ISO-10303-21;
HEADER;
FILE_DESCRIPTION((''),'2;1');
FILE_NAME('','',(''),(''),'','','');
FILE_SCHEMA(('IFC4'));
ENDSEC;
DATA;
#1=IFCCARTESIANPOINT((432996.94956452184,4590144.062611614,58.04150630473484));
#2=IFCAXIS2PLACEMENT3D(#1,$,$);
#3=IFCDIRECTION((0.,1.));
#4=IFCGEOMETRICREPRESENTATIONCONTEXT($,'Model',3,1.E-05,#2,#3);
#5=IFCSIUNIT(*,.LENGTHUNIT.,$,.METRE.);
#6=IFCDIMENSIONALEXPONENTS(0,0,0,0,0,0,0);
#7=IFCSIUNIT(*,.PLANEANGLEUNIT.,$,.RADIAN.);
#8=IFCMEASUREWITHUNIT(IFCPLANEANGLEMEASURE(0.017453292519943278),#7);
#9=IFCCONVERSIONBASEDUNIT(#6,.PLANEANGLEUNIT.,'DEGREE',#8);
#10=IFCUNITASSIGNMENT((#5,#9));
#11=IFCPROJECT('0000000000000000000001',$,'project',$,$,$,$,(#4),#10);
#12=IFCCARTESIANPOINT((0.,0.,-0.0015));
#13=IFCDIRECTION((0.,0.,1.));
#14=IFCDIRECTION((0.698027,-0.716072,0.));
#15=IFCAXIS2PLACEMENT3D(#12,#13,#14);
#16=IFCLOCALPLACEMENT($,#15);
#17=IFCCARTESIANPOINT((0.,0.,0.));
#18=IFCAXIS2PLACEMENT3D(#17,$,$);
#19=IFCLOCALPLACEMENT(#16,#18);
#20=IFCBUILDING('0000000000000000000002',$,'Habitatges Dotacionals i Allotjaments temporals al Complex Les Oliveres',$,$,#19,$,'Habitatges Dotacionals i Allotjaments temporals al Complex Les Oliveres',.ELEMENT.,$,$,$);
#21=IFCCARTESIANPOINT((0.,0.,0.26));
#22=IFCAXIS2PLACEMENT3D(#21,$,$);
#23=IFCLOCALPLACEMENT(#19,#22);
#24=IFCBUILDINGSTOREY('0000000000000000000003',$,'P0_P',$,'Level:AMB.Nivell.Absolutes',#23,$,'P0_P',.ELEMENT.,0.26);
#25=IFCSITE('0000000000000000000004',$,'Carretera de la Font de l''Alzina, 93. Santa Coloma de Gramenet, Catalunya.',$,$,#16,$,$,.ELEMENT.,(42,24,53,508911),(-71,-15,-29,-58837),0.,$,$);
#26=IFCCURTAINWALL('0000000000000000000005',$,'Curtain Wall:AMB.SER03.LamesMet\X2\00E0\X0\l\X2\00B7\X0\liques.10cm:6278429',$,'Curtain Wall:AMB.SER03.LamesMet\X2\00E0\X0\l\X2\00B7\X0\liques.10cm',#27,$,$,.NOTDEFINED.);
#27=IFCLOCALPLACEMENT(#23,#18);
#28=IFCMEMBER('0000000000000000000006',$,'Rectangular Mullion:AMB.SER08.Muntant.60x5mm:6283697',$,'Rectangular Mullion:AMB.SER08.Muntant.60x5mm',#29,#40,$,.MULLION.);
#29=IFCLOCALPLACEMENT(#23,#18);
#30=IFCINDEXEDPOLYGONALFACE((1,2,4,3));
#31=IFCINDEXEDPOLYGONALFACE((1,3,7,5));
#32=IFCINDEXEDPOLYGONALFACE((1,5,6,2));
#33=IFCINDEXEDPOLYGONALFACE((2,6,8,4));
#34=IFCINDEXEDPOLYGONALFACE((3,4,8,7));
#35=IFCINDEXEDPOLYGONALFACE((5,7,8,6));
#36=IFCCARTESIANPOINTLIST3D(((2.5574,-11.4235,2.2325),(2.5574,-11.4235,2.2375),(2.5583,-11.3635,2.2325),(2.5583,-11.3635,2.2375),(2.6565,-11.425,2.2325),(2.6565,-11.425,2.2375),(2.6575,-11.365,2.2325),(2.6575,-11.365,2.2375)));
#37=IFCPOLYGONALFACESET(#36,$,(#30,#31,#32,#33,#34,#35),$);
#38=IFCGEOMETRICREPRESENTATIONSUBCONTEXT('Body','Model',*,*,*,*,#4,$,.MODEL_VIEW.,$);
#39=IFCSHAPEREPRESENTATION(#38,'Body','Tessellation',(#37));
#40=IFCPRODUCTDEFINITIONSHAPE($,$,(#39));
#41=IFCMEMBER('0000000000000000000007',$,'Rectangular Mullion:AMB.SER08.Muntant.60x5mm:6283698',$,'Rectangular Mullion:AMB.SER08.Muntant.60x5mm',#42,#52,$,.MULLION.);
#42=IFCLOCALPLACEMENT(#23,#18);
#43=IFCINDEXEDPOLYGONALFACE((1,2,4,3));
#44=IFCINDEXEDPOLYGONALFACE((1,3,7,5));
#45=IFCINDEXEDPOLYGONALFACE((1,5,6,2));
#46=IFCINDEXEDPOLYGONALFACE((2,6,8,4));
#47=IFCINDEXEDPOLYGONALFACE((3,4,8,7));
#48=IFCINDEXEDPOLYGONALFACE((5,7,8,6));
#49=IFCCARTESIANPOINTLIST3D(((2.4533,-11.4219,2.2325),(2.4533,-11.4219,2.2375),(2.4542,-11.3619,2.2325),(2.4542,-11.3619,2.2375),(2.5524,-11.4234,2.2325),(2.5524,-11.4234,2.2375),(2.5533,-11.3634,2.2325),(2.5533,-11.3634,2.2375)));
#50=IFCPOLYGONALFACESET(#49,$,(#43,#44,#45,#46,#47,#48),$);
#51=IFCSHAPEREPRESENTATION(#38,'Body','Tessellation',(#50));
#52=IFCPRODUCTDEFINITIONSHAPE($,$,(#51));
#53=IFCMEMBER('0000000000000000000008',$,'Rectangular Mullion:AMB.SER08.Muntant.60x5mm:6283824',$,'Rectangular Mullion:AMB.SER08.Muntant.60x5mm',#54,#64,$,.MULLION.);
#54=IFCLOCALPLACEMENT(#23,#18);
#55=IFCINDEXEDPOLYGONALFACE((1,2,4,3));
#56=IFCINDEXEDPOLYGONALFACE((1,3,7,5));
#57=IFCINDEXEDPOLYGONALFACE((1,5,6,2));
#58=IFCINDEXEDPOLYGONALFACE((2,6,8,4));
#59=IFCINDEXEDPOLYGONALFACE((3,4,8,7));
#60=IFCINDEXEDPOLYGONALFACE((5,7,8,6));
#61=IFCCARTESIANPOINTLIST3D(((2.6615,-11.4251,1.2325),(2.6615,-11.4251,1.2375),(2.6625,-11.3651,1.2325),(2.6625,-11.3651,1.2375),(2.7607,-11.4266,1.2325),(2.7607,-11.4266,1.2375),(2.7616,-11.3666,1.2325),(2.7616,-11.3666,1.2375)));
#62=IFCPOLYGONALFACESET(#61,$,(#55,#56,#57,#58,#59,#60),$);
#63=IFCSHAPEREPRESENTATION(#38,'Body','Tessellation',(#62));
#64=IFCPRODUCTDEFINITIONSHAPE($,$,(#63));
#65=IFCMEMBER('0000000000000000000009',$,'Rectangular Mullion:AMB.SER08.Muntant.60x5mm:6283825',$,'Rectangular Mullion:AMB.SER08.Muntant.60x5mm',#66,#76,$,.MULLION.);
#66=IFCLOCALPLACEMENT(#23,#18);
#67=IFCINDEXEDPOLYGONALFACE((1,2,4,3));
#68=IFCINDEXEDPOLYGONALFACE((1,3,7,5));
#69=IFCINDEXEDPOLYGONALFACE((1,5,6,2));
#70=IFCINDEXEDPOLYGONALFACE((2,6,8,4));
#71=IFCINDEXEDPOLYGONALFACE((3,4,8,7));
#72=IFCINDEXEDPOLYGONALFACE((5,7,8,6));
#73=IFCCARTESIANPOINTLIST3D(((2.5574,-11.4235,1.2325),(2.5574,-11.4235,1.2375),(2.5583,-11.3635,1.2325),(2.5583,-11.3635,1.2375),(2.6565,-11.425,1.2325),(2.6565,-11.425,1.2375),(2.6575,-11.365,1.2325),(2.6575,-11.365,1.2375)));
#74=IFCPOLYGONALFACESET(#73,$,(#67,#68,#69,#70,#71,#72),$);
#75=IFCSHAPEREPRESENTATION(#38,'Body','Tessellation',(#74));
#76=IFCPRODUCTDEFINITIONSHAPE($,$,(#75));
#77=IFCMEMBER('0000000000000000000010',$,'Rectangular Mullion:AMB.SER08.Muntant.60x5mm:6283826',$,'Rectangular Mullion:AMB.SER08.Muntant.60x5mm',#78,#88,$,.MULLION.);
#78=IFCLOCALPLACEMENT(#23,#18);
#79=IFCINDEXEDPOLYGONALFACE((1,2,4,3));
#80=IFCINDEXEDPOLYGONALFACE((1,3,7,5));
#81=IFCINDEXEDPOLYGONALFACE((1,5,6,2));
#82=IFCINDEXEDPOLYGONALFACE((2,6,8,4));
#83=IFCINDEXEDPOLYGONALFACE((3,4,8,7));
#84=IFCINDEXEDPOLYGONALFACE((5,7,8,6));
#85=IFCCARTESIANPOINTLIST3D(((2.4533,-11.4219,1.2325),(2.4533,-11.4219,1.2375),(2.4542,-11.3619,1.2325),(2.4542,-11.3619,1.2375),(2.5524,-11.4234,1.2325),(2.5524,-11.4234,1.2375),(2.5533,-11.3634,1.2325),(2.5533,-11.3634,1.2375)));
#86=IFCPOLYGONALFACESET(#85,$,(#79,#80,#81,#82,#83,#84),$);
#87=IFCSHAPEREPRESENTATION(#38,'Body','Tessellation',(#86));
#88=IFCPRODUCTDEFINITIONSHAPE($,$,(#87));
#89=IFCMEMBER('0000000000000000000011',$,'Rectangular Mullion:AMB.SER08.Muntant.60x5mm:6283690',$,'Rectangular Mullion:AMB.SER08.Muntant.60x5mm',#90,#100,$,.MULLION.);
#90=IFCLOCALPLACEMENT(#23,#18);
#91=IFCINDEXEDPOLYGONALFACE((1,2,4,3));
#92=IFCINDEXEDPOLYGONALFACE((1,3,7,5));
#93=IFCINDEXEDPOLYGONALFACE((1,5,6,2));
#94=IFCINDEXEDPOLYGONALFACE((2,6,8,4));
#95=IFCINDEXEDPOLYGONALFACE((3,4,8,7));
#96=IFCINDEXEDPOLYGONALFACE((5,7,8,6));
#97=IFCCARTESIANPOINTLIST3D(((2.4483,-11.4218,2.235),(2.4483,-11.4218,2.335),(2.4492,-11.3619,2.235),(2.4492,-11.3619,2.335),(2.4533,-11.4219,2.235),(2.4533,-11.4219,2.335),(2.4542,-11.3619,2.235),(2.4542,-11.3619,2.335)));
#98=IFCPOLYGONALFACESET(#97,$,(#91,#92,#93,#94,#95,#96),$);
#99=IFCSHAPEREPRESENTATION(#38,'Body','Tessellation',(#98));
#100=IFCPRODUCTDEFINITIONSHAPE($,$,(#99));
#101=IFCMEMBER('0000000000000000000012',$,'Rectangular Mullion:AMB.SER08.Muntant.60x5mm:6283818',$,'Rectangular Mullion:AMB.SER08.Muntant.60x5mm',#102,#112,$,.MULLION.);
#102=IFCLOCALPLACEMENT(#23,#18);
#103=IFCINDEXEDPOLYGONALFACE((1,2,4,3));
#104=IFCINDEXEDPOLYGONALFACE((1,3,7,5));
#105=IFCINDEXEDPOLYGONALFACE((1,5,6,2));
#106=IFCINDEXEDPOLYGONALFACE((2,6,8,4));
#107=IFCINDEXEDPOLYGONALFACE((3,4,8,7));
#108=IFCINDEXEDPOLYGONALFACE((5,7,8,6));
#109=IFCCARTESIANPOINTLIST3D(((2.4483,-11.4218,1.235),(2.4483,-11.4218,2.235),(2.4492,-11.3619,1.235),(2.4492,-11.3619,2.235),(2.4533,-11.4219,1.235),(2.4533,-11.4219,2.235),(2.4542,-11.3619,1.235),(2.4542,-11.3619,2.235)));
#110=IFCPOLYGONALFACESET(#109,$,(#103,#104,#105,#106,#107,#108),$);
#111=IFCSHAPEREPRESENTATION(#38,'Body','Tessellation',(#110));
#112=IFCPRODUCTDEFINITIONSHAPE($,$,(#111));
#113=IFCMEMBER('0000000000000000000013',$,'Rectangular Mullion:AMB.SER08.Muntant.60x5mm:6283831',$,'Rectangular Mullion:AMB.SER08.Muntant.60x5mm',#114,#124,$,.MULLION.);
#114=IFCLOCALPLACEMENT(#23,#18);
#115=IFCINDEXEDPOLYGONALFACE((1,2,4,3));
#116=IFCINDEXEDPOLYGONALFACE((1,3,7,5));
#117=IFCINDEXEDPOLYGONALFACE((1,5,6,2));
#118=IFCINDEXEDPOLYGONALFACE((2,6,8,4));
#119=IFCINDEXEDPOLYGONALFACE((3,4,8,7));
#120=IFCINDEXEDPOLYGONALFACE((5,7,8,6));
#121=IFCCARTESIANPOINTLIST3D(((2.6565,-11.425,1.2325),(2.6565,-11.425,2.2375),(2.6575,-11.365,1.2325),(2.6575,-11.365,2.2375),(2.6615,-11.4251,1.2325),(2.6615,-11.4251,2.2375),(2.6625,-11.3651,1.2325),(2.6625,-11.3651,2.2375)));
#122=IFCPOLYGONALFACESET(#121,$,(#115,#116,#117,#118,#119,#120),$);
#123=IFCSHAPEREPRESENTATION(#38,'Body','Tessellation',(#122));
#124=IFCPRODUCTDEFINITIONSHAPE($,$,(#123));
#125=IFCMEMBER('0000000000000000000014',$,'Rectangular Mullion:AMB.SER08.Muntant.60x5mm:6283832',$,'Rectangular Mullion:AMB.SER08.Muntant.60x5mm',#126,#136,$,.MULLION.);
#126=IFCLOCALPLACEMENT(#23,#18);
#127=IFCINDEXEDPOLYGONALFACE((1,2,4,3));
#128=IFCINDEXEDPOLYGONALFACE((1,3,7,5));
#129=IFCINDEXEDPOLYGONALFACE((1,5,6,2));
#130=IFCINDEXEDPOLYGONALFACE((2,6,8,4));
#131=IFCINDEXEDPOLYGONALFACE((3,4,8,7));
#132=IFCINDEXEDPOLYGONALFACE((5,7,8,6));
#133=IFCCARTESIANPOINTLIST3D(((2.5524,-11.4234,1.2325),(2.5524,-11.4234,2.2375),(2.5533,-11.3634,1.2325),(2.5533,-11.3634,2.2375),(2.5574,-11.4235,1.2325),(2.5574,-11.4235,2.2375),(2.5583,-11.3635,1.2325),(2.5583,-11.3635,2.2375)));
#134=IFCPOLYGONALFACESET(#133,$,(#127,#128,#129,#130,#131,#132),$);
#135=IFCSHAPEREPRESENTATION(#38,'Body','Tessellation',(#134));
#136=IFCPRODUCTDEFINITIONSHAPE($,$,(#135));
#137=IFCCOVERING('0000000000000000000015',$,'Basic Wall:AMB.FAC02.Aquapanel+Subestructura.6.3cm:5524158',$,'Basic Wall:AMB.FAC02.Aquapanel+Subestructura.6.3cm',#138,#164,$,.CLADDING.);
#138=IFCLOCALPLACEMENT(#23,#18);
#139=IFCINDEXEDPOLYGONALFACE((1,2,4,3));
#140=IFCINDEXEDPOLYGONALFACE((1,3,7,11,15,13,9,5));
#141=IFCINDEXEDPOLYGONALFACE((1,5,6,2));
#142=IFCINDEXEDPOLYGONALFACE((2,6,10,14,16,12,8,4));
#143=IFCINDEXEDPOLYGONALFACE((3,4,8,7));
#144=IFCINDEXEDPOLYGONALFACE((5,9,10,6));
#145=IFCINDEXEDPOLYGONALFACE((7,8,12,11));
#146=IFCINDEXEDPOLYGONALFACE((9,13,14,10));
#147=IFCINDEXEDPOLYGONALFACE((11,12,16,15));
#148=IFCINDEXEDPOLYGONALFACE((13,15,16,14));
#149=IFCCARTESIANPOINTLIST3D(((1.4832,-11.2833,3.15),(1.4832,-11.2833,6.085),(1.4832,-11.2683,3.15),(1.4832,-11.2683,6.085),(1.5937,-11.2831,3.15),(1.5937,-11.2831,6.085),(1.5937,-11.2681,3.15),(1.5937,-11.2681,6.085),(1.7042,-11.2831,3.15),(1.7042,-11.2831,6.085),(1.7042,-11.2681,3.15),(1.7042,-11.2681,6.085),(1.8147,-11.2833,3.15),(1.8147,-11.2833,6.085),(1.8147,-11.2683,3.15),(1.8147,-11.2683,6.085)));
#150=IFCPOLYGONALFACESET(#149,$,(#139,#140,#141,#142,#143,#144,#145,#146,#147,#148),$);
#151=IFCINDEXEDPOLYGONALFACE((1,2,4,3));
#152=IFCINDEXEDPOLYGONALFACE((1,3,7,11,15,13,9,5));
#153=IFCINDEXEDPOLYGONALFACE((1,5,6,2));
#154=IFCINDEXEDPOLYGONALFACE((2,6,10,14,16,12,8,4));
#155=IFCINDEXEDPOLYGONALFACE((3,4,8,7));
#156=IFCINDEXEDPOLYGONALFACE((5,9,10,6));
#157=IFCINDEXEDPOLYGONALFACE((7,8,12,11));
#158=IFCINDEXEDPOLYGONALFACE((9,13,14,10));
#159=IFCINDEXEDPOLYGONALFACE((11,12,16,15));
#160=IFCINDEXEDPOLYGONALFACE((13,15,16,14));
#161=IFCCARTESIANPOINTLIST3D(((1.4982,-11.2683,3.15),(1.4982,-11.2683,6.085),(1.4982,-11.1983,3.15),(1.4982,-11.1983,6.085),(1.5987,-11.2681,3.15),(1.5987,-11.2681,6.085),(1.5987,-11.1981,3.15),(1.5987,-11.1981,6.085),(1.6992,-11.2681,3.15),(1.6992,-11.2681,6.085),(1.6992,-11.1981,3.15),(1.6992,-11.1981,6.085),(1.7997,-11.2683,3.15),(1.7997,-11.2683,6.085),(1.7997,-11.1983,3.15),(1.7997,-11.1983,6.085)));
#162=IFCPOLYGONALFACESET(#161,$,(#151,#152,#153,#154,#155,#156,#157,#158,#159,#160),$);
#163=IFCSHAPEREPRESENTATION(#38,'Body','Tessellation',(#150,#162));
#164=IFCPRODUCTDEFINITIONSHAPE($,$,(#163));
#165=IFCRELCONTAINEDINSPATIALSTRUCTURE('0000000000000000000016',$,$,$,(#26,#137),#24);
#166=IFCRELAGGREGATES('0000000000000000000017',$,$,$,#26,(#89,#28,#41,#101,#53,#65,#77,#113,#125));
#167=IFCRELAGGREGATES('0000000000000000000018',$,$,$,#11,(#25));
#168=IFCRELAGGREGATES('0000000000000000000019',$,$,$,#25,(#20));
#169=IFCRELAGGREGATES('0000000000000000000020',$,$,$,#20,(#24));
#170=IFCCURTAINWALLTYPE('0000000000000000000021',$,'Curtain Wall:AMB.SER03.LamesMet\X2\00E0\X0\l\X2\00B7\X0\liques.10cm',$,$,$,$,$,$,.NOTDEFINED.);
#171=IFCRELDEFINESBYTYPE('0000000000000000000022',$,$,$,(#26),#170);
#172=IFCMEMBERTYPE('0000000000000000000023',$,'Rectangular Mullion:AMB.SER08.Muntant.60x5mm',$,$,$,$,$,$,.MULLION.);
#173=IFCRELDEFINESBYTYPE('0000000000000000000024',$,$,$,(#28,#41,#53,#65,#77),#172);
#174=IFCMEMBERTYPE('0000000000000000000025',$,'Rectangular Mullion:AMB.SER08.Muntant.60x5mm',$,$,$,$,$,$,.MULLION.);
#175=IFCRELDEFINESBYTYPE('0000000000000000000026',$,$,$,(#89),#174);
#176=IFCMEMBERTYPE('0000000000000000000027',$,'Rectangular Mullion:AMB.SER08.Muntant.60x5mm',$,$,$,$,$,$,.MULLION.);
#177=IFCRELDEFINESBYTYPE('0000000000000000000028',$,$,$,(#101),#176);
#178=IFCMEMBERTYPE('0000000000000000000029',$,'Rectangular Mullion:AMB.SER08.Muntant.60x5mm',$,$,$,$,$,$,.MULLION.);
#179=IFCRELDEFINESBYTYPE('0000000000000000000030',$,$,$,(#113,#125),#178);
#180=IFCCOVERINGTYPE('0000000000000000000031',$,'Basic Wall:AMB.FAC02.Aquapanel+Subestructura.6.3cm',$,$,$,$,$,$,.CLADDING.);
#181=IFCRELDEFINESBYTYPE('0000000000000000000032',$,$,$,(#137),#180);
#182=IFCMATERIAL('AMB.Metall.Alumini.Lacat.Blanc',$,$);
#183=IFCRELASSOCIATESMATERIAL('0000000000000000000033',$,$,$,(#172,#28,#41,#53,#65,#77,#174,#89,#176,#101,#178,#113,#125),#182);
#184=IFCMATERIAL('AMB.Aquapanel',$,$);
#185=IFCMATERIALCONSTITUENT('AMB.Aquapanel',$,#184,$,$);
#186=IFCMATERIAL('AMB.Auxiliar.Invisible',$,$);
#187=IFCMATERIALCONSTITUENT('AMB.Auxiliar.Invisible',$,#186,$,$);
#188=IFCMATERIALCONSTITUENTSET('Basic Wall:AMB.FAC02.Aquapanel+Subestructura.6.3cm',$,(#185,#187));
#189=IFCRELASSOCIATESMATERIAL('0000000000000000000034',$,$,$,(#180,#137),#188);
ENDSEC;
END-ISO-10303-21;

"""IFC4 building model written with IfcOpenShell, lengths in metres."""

from ifc_helpers import new_model, entity, si_unit, converted_unit, direction, frame, origin, place, context, subcontext, project, spatial, line, arc, indexed_curve, outline, extrude, source, transform, mapped, material, constituent, constituent_set, type_object, type_shapes, element, aggregate, save


model = new_model("IFC4")

# Units and contexts
model_context = context("Model", 3, precision=1e-05, world=frame((432996.94956452184, 4590144.062611614, 58.04150630473484)), true_north=direction((0.0, 1.0)))
body_context = subcontext(model_context, "Body", "Model", "MODEL_VIEW")
ifc_project = project(units=[si_unit("LENGTHUNIT", "METRE"), converted_unit("PLANEANGLEUNIT", "DEGREE", entity("IfcPlaneAngleMeasure", 0.017453292519943278), si_unit("PLANEANGLEUNIT", "RADIAN"), dimensions=[0, 0, 0, 0, 0, 0, 0])], contexts=[model_context])

# Site, building, storey
site_placement = place(None, frame((0.0, 0.0, -0.0015), z_axis=(0.0, 0.0, 1.0), x_axis=(0.698027, -0.716072, 0.0)))
site = spatial("IfcSite", under=ifc_project, at=site_placement, Name="Carretera de la Font de l'Alzina, 93. Santa Coloma de Gramenet, Catalunya.", CompositionType="ELEMENT", RefLatitude=(42, 24, 53, 508911), RefLongitude=(-71, -15, -29, -58837), RefElevation=0.0)
building_placement = place(site_placement, origin())
building = spatial("IfcBuilding", under=site, at=building_placement, Name="Habitatges Dotacionals i Allotjaments temporals al Complex Les Oliveres", LongName="Habitatges Dotacionals i Allotjaments temporals al Complex Les Oliveres", CompositionType="ELEMENT")
storey_placement = place(building_placement, frame((0.0, 0.0, 0.26)))
storey = spatial("IfcBuildingStorey", under=building, at=storey_placement, Name="P0_P", ObjectType="Level:AMB.Nivell.Absolutes", LongName="P0_P", CompositionType="ELEMENT", Elevation=0.26)

# Shared definitions
ifc_material_1 = material(Name="AMB.Metall.Alumini.Lacat.Blanc")

# Curtain wall, members
curtain_wall_type_1 = type_object("IfcCurtainWallType", Name="Curtain Wall:AMB.SER03.LamesMetàl·liques.10cm", PredefinedType="NOTDEFINED")
curtain_wall_1_placement = place(storey_placement, frame((0.0, 0.0, -0.26)))
curtain_wall_1 = element("IfcCurtainWall", 1, at=curtain_wall_1_placement, inside=storey, type_object=curtain_wall_type_1, Name="Curtain Wall:AMB.SER03.LamesMetàl·liques.10cm:6278429", ObjectType="Curtain Wall:AMB.SER03.LamesMetàl·liques.10cm", PredefinedType="NOTDEFINED")
member_type_1 = type_object("IfcMemberType", Name="Rectangular Mullion:AMB.SER08.Muntant.60x5mm", PredefinedType="MULLION", material=ifc_material_1)
shared_shape_1 = source(origin(), body_context, "Body", "SweptSolid", [
    extrude(outline(indexed_curve([(-0.0025, -0.03), (0.0025, -0.03), (0.0025, 0.03), (-0.0025, 0.03), (-0.0025, -0.03)], self_intersect=False)), frame((0.0, 0.03, -0.0991), z_axis=(0.0, 0.0, 1.0), x_axis=(-1.0, 0.0, 0.0)), (0.0, 0.0, 1.0), 0.0991),
])
type_shapes(member_type_1, [shared_shape_1])
member_1_placement = place(curtain_wall_1_placement, frame((2.5574, -11.4235, 2.495), z_axis=(-0.999883, 0.015319, 0.0), x_axis=(0.0, 0.0, 1.0)))
member_1 = element("IfcMember", 2, at=member_1_placement, type_object=member_type_1, material=ifc_material_1, Name="Rectangular Mullion:AMB.SER08.Muntant.60x5mm:6283697", ObjectType="Rectangular Mullion:AMB.SER08.Muntant.60x5mm", PredefinedType="MULLION", context=body_context, shape_type="MappedRepresentation", body=[
    mapped(shared_shape_1, transform((0.0, 0.0, 0.0), scale=1.0)),
])
member_2_placement = place(curtain_wall_1_placement, frame((2.4533, -11.4219, 2.495), z_axis=(-0.999883, 0.015319, 0.0), x_axis=(0.0, 0.0, 1.0)))
member_2 = element("IfcMember", 3, at=member_2_placement, type_object=member_type_1, material=ifc_material_1, Name="Rectangular Mullion:AMB.SER08.Muntant.60x5mm:6283698", ObjectType="Rectangular Mullion:AMB.SER08.Muntant.60x5mm", PredefinedType="MULLION", context=body_context, shape_type="MappedRepresentation", body=[
    mapped(shared_shape_1, transform((0.0, 0.0, 0.0), scale=1.0)),
])
member_3_placement = place(curtain_wall_1_placement, frame((2.6615, -11.4251, 1.495), z_axis=(-0.999883, 0.015319, 0.0), x_axis=(0.0, 0.0, 1.0)))
member_3 = element("IfcMember", 4, at=member_3_placement, type_object=member_type_1, material=ifc_material_1, Name="Rectangular Mullion:AMB.SER08.Muntant.60x5mm:6283824", ObjectType="Rectangular Mullion:AMB.SER08.Muntant.60x5mm", PredefinedType="MULLION", context=body_context, shape_type="MappedRepresentation", body=[
    mapped(shared_shape_1, transform((0.0, 0.0, 0.0), scale=1.0)),
])
member_4_placement = place(curtain_wall_1_placement, frame((2.5574, -11.4235, 1.495), z_axis=(-0.999883, 0.015319, 0.0), x_axis=(0.0, 0.0, 1.0)))
member_4 = element("IfcMember", 5, at=member_4_placement, type_object=member_type_1, material=ifc_material_1, Name="Rectangular Mullion:AMB.SER08.Muntant.60x5mm:6283825", ObjectType="Rectangular Mullion:AMB.SER08.Muntant.60x5mm", PredefinedType="MULLION", context=body_context, shape_type="MappedRepresentation", body=[
    mapped(shared_shape_1, transform((0.0, 0.0, 0.0), scale=1.0)),
])
member_5_placement = place(curtain_wall_1_placement, frame((2.4533, -11.4219, 1.495), z_axis=(-0.999883, 0.015319, 0.0), x_axis=(0.0, 0.0, 1.0)))
member_5 = element("IfcMember", 6, at=member_5_placement, type_object=member_type_1, material=ifc_material_1, Name="Rectangular Mullion:AMB.SER08.Muntant.60x5mm:6283826", ObjectType="Rectangular Mullion:AMB.SER08.Muntant.60x5mm", PredefinedType="MULLION", context=body_context, shape_type="MappedRepresentation", body=[
    mapped(shared_shape_1, transform((0.0, 0.0, 0.0), scale=1.0)),
])
member_type_2 = type_object("IfcMemberType", Name="Rectangular Mullion:AMB.SER08.Muntant.60x5mm", PredefinedType="MULLION", material=ifc_material_1)
shared_shape_2 = source(origin(), body_context, "Body", "SweptSolid", [
    extrude(outline(indexed_curve([(-0.0025, -0.03), (0.0025, -0.03), (0.0025, 0.03), (-0.0025, 0.03), (-0.0025, -0.03)], self_intersect=False)), frame((-0.0025, 0.03, -0.1), z_axis=(0.0, 0.0, 1.0), x_axis=(-1.0, 0.0, 0.0)), (0.0, 0.0, 1.0), 0.1),
])
type_shapes(member_type_2, [shared_shape_2])
member_6_placement = place(curtain_wall_1_placement, frame((2.4483, -11.4218, 2.495), z_axis=(0.0, 0.0, -1.0), x_axis=(-0.999883, 0.015319, 0.0)))
member_6 = element("IfcMember", 7, at=member_6_placement, type_object=member_type_2, material=ifc_material_1, Name="Rectangular Mullion:AMB.SER08.Muntant.60x5mm:6283690", ObjectType="Rectangular Mullion:AMB.SER08.Muntant.60x5mm", PredefinedType="MULLION", context=body_context, shape_type="MappedRepresentation", body=[
    mapped(shared_shape_2, transform((0.0, 0.0, 0.0), scale=1.0)),
])
member_type_3 = type_object("IfcMemberType", Name="Rectangular Mullion:AMB.SER08.Muntant.60x5mm", PredefinedType="MULLION", material=ifc_material_1)
shared_shape_3 = source(origin(), body_context, "Body", "SweptSolid", [
    extrude(outline(indexed_curve([(-0.0025, -0.03), (0.0025, -0.03), (0.0025, 0.03), (-0.0025, 0.03), (-0.0025, -0.03)], self_intersect=False)), frame((-0.0025, 0.03, -1.0), z_axis=(0.0, 0.0, 1.0), x_axis=(-1.0, 0.0, 0.0)), (0.0, 0.0, 1.0), 1.0),
])
type_shapes(member_type_3, [shared_shape_3])
member_7_placement = place(curtain_wall_1_placement, frame((2.4483, -11.4218, 1.495), z_axis=(0.0, 0.0, -1.0), x_axis=(-0.999883, 0.015319, 0.0)))
member_7 = element("IfcMember", 8, at=member_7_placement, type_object=member_type_3, material=ifc_material_1, Name="Rectangular Mullion:AMB.SER08.Muntant.60x5mm:6283818", ObjectType="Rectangular Mullion:AMB.SER08.Muntant.60x5mm", PredefinedType="MULLION", context=body_context, shape_type="MappedRepresentation", body=[
    mapped(shared_shape_3, transform((0.0, 0.0, 0.0), scale=1.0)),
])
member_type_4 = type_object("IfcMemberType", Name="Rectangular Mullion:AMB.SER08.Muntant.60x5mm", PredefinedType="MULLION", material=ifc_material_1)
shared_shape_4 = source(origin(), body_context, "Body", "SweptSolid", [
    extrude(outline(indexed_curve([(-0.0025, -0.03), (0.0025, -0.03), (0.0025, 0.03), (-0.0025, 0.03), (-0.0025, -0.03)], self_intersect=False)), frame((0.0, 0.03, -1.005), z_axis=(0.0, 0.0, 1.0), x_axis=(-1.0, 0.0, 0.0)), (0.0, 0.0, 1.0), 1.005),
])
type_shapes(member_type_4, [shared_shape_4])
member_8_placement = place(curtain_wall_1_placement, frame((2.659, -11.4251, 1.4925), z_axis=(0.0, 0.0, -1.0), x_axis=(-0.999883, 0.015319, 0.0)))
member_8 = element("IfcMember", 9, at=member_8_placement, type_object=member_type_4, material=ifc_material_1, Name="Rectangular Mullion:AMB.SER08.Muntant.60x5mm:6283831", ObjectType="Rectangular Mullion:AMB.SER08.Muntant.60x5mm", PredefinedType="MULLION", context=body_context, shape_type="MappedRepresentation", body=[
    mapped(shared_shape_4, transform((0.0, 0.0, 0.0), scale=1.0)),
])
member_9_placement = place(curtain_wall_1_placement, frame((2.5549, -11.4235, 1.4925), z_axis=(0.0, 0.0, -1.0), x_axis=(-0.999883, 0.015319, 0.0)))
member_9 = element("IfcMember", 10, at=member_9_placement, type_object=member_type_4, material=ifc_material_1, Name="Rectangular Mullion:AMB.SER08.Muntant.60x5mm:6283832", ObjectType="Rectangular Mullion:AMB.SER08.Muntant.60x5mm", PredefinedType="MULLION", context=body_context, shape_type="MappedRepresentation", body=[
    mapped(shared_shape_4, transform((0.0, 0.0, 0.0), scale=1.0)),
])
aggregate(curtain_wall_1, [member_6, member_1, member_2, member_7, member_3, member_4, member_5, member_8, member_9])

# Covering
ifc_material_2 = material(Name="AMB.Aquapanel")
ifc_constituent_1 = constituent(ifc_material_2, Name="AMB.Aquapanel")
ifc_material_3 = material(Name="AMB.Auxiliar.Invisible")
ifc_constituent_2 = constituent(ifc_material_3, Name="AMB.Auxiliar.Invisible")
ifc_constituent_set = constituent_set(constituents=[ifc_constituent_1, ifc_constituent_2], Name="Basic Wall:AMB.FAC02.Aquapanel+Subestructura.6.3cm")
covering_type_1 = type_object("IfcCoveringType", Name="Basic Wall:AMB.FAC02.Aquapanel+Subestructura.6.3cm", PredefinedType="CLADDING", material=ifc_constituent_set)
covering_1_placement = place(storey_placement, frame((1.8149, -11.2408, 3.15)))
element("IfcCovering", 11, at=covering_1_placement, inside=storey, type_object=covering_type_1, material=ifc_constituent_set, Name="Basic Wall:AMB.FAC02.Aquapanel+Subestructura.6.3cm:5524158", ObjectType="Basic Wall:AMB.FAC02.Aquapanel+Subestructura.6.3cm", PredefinedType="CLADDING", context=body_context, shape_type="SweptSolid", body=[
    extrude(outline(indexed_curve([(-0.0075, -0.1658), (0.0075, -0.1658), (0.0078, 0.0), (0.0075, 0.1658), (-0.0075, 0.1658), (-0.0072, 0.0)], segments=[line(1, 2), arc(2, 3, 4), line(4, 5), arc(5, 6, 1)], self_intersect=False)), frame((-0.1659, -0.035, 0.0), z_axis=(0.0, 0.0, 1.0), x_axis=(0.0, 1.0, 0.0)), (0.0, 0.0, 1.0), 2.935),
    extrude(outline(indexed_curve([(-0.035, -0.1508), (0.035, -0.1508), (0.0348, 0.0), (0.035, 0.1508), (-0.035, 0.1508), (-0.0352, 0.0)], segments=[line(1, 2), arc(2, 3, 4), line(4, 5), arc(5, 6, 1)], self_intersect=False)), frame((-0.1659, 0.0075, 0.0), z_axis=(0.0, 0.0, 1.0), x_axis=(0.0, -1.0, 0.0)), (0.0, 0.0, 1.0), 2.935),
])

save(model, "model.ifc")
